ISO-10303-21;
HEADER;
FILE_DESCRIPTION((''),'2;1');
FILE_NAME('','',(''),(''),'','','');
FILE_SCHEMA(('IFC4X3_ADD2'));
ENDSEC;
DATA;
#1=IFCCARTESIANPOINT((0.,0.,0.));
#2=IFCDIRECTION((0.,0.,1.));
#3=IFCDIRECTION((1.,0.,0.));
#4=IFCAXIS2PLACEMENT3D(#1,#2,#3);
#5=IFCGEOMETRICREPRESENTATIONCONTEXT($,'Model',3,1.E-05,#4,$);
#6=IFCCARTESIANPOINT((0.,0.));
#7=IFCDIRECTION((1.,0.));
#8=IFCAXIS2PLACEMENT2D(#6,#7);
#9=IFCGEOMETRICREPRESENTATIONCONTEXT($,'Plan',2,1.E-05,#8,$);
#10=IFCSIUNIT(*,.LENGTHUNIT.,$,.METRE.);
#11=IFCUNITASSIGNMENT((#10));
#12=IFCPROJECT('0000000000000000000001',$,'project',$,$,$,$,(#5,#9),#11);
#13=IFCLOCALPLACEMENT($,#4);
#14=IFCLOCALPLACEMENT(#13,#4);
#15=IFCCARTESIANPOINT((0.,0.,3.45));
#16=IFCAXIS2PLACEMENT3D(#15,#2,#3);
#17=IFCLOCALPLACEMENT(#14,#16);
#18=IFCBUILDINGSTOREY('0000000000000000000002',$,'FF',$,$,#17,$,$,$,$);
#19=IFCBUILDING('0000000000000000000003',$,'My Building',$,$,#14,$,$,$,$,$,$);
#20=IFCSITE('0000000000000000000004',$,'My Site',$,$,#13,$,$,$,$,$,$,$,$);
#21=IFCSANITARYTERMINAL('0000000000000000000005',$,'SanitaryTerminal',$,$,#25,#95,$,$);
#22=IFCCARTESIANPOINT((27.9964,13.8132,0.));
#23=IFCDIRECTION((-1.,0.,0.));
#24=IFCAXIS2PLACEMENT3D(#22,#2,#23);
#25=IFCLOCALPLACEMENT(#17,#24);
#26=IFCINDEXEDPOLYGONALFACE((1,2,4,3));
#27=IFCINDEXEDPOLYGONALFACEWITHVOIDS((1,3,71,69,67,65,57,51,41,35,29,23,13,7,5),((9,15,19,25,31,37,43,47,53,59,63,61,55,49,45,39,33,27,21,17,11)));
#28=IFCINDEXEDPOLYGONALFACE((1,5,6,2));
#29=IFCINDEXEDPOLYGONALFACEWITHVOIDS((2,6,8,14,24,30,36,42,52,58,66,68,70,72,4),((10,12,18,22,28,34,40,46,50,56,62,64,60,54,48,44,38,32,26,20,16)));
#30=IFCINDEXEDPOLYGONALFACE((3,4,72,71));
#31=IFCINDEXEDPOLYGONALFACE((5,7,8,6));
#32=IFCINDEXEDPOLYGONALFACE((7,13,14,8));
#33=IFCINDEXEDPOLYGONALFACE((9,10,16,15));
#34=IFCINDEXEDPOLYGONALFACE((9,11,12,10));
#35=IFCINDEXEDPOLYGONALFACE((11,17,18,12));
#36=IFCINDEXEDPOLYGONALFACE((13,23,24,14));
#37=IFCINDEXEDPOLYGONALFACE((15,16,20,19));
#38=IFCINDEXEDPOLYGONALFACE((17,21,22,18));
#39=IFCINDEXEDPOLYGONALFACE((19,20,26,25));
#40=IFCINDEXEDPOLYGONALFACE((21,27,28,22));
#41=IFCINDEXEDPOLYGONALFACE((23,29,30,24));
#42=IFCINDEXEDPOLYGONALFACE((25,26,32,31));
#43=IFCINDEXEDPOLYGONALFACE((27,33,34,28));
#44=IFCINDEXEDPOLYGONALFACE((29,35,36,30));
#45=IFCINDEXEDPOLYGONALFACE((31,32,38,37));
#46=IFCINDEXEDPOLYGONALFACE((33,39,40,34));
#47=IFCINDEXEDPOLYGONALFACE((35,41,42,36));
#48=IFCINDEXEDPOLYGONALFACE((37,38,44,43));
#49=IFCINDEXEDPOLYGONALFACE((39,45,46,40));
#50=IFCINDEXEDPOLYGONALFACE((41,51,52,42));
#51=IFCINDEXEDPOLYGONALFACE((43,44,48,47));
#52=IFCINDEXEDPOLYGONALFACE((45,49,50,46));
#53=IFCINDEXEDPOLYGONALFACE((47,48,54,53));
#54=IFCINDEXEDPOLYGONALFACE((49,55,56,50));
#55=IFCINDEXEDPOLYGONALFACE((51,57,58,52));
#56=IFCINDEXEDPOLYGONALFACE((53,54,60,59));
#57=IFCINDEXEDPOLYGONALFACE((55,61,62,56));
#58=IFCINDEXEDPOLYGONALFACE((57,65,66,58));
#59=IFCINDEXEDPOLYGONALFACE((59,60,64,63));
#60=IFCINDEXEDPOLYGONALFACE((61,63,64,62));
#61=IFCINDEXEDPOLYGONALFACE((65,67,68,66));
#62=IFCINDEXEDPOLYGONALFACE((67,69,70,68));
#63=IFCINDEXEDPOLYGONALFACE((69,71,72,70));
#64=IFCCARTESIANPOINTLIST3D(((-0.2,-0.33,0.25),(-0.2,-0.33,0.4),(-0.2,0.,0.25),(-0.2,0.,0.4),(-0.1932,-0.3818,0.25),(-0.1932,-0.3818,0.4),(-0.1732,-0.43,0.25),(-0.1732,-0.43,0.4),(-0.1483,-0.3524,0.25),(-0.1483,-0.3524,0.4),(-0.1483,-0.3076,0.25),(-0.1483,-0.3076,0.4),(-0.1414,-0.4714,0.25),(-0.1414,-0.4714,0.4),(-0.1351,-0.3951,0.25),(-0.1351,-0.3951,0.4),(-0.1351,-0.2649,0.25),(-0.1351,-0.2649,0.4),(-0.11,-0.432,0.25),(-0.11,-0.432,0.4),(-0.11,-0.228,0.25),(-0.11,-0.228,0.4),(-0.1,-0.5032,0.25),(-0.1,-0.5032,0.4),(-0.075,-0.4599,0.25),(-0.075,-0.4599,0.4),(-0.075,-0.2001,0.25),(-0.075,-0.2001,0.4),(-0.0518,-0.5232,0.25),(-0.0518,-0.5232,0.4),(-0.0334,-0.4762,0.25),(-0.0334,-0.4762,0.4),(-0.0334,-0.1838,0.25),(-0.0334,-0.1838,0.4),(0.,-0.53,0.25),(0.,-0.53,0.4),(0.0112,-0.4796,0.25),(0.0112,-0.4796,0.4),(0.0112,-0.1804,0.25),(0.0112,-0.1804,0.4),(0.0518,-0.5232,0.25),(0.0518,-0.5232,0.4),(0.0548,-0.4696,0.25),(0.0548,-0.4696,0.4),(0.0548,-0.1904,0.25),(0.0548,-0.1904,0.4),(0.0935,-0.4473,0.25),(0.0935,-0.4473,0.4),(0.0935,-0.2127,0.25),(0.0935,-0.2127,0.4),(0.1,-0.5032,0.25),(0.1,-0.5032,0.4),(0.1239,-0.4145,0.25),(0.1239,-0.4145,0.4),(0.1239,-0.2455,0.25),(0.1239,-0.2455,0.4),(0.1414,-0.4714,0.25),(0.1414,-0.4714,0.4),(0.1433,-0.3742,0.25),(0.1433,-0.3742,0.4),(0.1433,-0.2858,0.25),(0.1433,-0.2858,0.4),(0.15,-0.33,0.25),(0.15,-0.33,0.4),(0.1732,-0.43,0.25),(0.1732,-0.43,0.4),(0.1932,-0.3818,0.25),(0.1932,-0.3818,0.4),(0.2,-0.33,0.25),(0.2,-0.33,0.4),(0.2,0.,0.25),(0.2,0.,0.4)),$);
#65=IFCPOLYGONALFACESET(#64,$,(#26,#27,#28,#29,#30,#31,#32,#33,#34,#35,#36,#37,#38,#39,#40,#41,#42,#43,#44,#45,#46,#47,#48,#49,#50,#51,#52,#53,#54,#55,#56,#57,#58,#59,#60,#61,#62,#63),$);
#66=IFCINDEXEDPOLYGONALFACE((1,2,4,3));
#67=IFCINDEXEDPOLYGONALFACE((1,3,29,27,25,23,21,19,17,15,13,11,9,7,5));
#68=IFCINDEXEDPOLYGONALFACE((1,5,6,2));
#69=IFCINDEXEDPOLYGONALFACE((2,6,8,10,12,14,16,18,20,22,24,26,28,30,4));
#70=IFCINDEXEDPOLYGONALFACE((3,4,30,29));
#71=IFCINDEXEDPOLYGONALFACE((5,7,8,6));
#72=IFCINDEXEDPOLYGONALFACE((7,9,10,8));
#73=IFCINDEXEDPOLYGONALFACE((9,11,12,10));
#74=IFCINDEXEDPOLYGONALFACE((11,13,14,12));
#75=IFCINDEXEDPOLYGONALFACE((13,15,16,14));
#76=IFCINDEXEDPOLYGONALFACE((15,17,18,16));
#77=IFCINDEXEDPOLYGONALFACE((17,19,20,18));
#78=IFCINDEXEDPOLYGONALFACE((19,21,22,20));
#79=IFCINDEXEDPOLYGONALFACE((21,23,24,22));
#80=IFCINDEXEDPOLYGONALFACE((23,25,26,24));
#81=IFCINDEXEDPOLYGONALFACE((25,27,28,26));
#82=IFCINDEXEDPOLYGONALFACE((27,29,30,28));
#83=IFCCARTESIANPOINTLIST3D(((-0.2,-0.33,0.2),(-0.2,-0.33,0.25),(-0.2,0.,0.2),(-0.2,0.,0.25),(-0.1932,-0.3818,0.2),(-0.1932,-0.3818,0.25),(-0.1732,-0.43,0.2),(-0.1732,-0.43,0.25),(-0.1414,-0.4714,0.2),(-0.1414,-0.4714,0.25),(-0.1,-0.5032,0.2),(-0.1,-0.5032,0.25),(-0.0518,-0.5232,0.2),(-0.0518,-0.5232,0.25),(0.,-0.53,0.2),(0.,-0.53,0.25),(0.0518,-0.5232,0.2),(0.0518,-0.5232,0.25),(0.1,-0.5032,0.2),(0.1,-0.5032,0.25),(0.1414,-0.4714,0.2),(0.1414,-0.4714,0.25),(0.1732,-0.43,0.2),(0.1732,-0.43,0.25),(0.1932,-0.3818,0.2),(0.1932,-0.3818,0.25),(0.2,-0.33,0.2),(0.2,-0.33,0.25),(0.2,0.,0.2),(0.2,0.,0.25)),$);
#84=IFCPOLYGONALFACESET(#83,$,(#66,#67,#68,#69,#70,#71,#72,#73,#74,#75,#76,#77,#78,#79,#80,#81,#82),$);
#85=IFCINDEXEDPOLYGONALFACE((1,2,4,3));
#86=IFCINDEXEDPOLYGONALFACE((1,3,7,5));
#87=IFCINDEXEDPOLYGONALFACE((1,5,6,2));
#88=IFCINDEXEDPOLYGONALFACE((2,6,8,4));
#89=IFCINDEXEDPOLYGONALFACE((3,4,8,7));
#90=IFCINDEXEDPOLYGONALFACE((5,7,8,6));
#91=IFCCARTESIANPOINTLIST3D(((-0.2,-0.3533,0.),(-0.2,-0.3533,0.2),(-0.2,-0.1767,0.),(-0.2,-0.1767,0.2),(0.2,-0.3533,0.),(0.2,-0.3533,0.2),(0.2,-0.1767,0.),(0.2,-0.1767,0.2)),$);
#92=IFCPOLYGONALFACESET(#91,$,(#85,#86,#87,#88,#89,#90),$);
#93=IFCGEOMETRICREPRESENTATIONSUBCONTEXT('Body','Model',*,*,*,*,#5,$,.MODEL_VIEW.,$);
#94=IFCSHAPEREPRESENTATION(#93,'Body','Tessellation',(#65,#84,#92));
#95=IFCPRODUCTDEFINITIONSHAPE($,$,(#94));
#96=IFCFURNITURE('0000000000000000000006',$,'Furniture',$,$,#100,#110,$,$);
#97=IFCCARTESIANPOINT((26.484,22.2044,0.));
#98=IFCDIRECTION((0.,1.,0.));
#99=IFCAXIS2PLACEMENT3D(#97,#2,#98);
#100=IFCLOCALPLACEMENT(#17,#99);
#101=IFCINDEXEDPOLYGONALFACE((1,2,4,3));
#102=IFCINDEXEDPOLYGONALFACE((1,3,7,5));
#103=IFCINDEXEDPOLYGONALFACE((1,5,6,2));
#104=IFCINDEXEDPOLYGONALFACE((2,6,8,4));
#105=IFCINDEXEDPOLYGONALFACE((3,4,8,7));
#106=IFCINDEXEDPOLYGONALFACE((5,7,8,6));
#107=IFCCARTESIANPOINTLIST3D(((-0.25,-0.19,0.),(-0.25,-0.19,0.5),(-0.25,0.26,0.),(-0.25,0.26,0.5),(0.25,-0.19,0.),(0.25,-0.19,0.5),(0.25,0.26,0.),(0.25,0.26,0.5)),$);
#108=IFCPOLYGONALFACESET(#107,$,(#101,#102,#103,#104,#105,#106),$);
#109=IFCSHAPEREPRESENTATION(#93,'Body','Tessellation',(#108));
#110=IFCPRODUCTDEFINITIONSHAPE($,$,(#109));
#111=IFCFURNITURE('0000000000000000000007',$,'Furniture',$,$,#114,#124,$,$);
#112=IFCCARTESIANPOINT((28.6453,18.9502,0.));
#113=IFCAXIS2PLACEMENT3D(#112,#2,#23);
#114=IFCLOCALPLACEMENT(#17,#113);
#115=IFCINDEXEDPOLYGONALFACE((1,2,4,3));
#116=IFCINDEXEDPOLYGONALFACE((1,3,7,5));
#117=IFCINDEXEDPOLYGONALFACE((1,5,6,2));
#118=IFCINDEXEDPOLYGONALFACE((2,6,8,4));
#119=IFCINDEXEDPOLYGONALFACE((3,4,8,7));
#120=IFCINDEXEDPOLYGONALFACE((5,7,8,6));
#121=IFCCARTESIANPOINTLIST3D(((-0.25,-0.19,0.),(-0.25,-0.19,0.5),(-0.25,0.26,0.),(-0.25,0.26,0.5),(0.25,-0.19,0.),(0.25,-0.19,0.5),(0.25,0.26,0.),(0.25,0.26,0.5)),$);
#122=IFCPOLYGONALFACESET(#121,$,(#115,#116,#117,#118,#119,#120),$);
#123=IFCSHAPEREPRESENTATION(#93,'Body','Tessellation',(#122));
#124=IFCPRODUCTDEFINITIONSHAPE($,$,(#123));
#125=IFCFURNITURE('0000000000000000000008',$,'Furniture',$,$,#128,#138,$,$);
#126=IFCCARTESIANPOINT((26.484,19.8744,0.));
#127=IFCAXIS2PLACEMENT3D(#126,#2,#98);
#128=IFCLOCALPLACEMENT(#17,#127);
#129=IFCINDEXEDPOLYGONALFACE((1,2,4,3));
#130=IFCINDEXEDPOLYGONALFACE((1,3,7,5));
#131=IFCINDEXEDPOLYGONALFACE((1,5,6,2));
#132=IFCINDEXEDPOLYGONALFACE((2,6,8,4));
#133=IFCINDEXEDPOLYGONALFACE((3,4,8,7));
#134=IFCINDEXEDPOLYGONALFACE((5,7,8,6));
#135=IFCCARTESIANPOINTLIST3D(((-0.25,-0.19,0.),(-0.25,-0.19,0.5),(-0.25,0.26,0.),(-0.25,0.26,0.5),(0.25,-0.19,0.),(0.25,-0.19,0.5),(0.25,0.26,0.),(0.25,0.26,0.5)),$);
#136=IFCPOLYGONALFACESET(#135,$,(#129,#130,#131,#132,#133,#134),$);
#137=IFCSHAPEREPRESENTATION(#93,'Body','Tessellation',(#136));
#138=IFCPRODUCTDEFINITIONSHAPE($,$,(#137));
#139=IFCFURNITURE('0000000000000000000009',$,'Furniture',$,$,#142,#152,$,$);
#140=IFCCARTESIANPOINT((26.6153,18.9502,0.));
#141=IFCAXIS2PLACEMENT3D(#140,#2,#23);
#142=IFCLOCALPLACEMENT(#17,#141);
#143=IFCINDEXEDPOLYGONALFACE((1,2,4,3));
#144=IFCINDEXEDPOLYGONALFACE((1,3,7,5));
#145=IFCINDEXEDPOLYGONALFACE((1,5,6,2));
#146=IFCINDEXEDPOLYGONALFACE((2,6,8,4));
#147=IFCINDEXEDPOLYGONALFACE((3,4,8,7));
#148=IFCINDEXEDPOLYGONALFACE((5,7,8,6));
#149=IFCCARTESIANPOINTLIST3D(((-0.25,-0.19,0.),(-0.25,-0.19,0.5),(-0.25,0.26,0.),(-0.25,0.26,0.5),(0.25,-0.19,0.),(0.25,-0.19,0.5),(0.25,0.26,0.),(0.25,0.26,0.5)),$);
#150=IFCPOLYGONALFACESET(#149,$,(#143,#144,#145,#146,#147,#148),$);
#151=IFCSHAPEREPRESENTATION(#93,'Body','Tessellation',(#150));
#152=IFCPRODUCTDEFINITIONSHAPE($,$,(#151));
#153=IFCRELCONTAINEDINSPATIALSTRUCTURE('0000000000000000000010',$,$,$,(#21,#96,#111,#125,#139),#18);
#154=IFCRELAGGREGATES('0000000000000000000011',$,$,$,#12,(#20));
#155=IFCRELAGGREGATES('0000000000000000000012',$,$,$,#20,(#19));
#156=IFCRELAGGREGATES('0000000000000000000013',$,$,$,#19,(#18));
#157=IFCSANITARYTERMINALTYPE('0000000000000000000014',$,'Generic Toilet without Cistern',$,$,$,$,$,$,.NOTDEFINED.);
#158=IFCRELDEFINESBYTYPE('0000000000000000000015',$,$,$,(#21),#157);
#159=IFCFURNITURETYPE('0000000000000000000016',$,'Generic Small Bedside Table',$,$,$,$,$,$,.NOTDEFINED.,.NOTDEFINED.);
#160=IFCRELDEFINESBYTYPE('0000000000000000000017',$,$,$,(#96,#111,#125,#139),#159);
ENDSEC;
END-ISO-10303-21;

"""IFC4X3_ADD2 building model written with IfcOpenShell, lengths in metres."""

from ifc_helpers import new_model, entity, si_unit, frame, frame_2d, origin_with_axes, origin_2d_with_axis, place, context, subcontext, project, spatial, line, arc, indexed_curve, circle_curve, outline, extrude, shape, source, transform, mapped, type_object, type_shapes, element, save


model = new_model("IFC4X3_ADD2")

# Units and contexts
model_context = context("Model", 3, precision=1e-05, world=origin_with_axes())
plan_context = context("Plan", 2, precision=1e-05, world=origin_2d_with_axis())
body_context_1 = subcontext(model_context, "Body", "Model", "MODEL_VIEW")
body_context_2 = subcontext(plan_context, "Body", "Plan", "PLAN_VIEW")
ifc_project = project(units=[si_unit("LENGTHUNIT", "METRE")], contexts=[model_context, plan_context])

# Site, building, storey
site_placement = place(None, origin_with_axes())
site = spatial("IfcSite", under=ifc_project, at=site_placement, Name="My Site")
building_placement = place(site_placement, origin_with_axes())
building = spatial("IfcBuilding", under=site, at=building_placement, Name="My Building")
storey_placement = place(building_placement, frame((0.0, 0.0, 3.45), z_axis=(0.0, 0.0, 1.0), x_axis=(1.0, 0.0, 0.0)))
storey = spatial("IfcBuildingStorey", under=building, at=storey_placement, Name="FF")

# Sanitary terminal
sanitary_terminal_type_1 = type_object("IfcSanitaryTerminalType", Name="Generic Toilet without Cistern", PredefinedType="NOTDEFINED")
shared_shape_1 = source(origin_with_axes(), body_context_1, "Body", "SweptSolid", [
    extrude(outline(indexed_curve([(-0.2, 0.0), (0.2, 0.0), (0.2, -0.33), (0.1414, -0.4714), (0.0, -0.53), (-0.1414, -0.4714), (-0.2, -0.33)], segments=[line(1, 2), line(2, 3), arc(3, 4, 5), arc(5, 6, 7), line(7, 1)]), holes=[circle_curve(frame_2d((0.0, -0.33)), 0.15)]), frame((0.0, 0.0, 0.25), z_axis=(0.0, 0.0, 1.0), x_axis=(1.0, 0.0, 0.0)), (0.0, 0.0, 1.0), 0.15),
    extrude(outline(indexed_curve([(-0.2, 0.0), (0.2, 0.0), (0.2, -0.33), (0.1414, -0.4714), (0.0, -0.53), (-0.1414, -0.4714), (-0.2, -0.33)], segments=[line(1, 2), line(2, 3), arc(3, 4, 5), arc(5, 6, 7), line(7, 1)])), frame((0.0, 0.0, 0.2), z_axis=(0.0, 0.0, 1.0), x_axis=(1.0, 0.0, 0.0)), (0.0, 0.0, 1.0), 0.05),
    extrude(outline(indexed_curve([(-0.2, -0.1767), (0.2, -0.1767), (0.2, -0.3533), (-0.2, -0.3533)], segments=[line(1, 2, 3, 4, 1)])), origin_with_axes(), (0.0, 0.0, 1.0), 0.2),
])
shared_shape_2 = source(origin_with_axes(), body_context_2, "Body", "Annotation2D", [
    entity("IfcGeometricCurveSet", [entity("IfcIndexedPolyCurve", entity("IfcCartesianPointList2D", [[-0.1068, -0.124], [-0.0957, -0.1129], [-0.0804, -0.1088], [0.0804, -0.1088], [0.0957, -0.1129], [0.1068, -0.124], [0.1109, -0.1393], [0.1109, -0.3476], [0.1025, -0.3926], [0.0784, -0.4308], [0.0424, -0.4563], [0.0, -0.4652], [-0.0424, -0.4563], [-0.0784, -0.4308], [-0.1025, -0.3926], [-0.1109, -0.3476], [-0.1109, -0.1393]]), [entity("IfcLineIndex", [1, 2, 3, 4, 5, 6, 7, 8, 9, 10, 11, 12, 13, 14, 15, 16, 17, 1])]), entity("IfcIndexedPolyCurve", entity("IfcCartesianPointList2D", [[-0.1962, -0.2314], [-0.1848, -0.301], [-0.1764, -0.3339], [-0.1663, -0.3651], [-0.1546, -0.3944], [-0.1414, -0.4213], [-0.1269, -0.4458], [-0.1111, -0.4675], [-0.0943, -0.4862], [-0.0765, -0.5018], [-0.0581, -0.514], [-0.039, -0.5229], [-0.0196, -0.5282], [0.0, -0.53], [0.0196, -0.5282], [0.039, -0.5229], [0.0581, -0.514], [0.0765, -0.5018], [0.0943, -0.4862], [0.1111, -0.4675], [0.1269, -0.4458], [0.1414, -0.4213], [0.1546, -0.3944], [0.1663, -0.3651], [0.1764, -0.3339], [0.1848, -0.301], [0.1962, -0.2314], [0.2, -0.159], [0.1872, 0.0], [-0.1872, 0.0], [-0.2, -0.159]]), [entity("IfcLineIndex", [1, 2, 3, 4, 5, 6, 7, 8, 9, 10, 11, 12, 13, 14, 15, 16, 17, 18, 19, 20, 21, 22, 23, 24, 25, 26, 27, 28, 29, 30, 31, 1])])]),
])
type_shapes(sanitary_terminal_type_1, [shared_shape_1, shared_shape_2])
sanitary_terminal_1_placement = place(storey_placement, frame((27.9964, 13.8132, 0.0), z_axis=(0.0, 0.0, 1.0), x_axis=(-1.0, 0.0, 0.0)))
element("IfcSanitaryTerminal", 1, at=sanitary_terminal_1_placement, inside=storey, type_object=sanitary_terminal_type_1, Name="SanitaryTerminal", shapes=[
    shape(body_context_1, "Body", "MappedRepresentation", [mapped(shared_shape_1, transform((0.0, 0.0, 0.0), x_axis=(1.0, 0.0, 0.0), y_axis=(0.0, 1.0, 0.0), z_axis=(0.0, 0.0, 1.0), scale=1.0))]),
    shape(body_context_2, "Body", "MappedRepresentation", [mapped(shared_shape_2, transform((0.0, 0.0, 0.0), x_axis=(1.0, 0.0, 0.0), y_axis=(0.0, 1.0, 0.0), z_axis=(0.0, 0.0, 1.0), scale=1.0))]),
])

# Furniture
furniture_type_1 = type_object("IfcFurnitureType", Name="Generic Small Bedside Table", AssemblyPlace="NOTDEFINED", PredefinedType="NOTDEFINED")
shared_shape_3 = source(origin_with_axes(), body_context_1, "Body", "SweptSolid", [
    extrude(outline(indexed_curve([(0.5, 0.45), (0.5, 0.0), (0.0, 0.0), (0.0, 0.45)], segments=[line(4, 1), line(1, 2), line(2, 3), line(3, 4)], self_intersect=False)), frame((-0.25, -0.19, 0.0), z_axis=(0.0, 0.0, 1.0), x_axis=(1.0, 0.0, 0.0)), (0.0, 0.0, 1.0), 0.5),
])
shared_shape_4 = source(origin_with_axes(), body_context_2, "Body", "Annotation2D", [
    entity("IfcGeometricCurveSet", [entity("IfcIndexedPolyCurve", entity("IfcCartesianPointList2D", [[-0.25, -0.19], [0.25, -0.19], [0.25, 0.26], [-0.25, 0.26]]), [entity("IfcLineIndex", [1, 2]), entity("IfcLineIndex", [2, 3]), entity("IfcLineIndex", [3, 4]), entity("IfcLineIndex", [4, 1])])]),
])
type_shapes(furniture_type_1, [shared_shape_3, shared_shape_4])
for number, where, z_axis, x_axis, name in (
    (2, (26.484, 22.2044, 0.0), (0.0, 0.0, 1.0), (0.0, 1.0, 0.0), "Furniture"),
    (3, (28.6453, 18.9502, 0.0), (0.0, 0.0, 1.0), (-1.0, 0.0, 0.0), "Furniture"),
    (4, (26.484, 19.8744, 0.0), (0.0, 0.0, 1.0), (0.0, 1.0, 0.0), "Furniture"),
    (5, (26.6153, 18.9502, 0.0), (0.0, 0.0, 1.0), (-1.0, 0.0, 0.0), "Furniture"),
):
    element("IfcFurniture", number, at=place(storey_placement, frame(where, z_axis=z_axis, x_axis=x_axis)), inside=storey, type_object=furniture_type_1, Name=name, shapes=[
        shape(body_context_1, "Body", "MappedRepresentation", [mapped(shared_shape_3, transform((0.0, 0.0, 0.0), x_axis=(1.0, 0.0, 0.0), y_axis=(0.0, 1.0, 0.0), z_axis=(0.0, 0.0, 1.0), scale=1.0))]),
        shape(body_context_2, "Body", "MappedRepresentation", [mapped(shared_shape_4, transform((0.0, 0.0, 0.0), x_axis=(1.0, 0.0, 0.0), y_axis=(0.0, 1.0, 0.0), z_axis=(0.0, 0.0, 1.0), scale=1.0))]),
    ])

save(model, "model.ifc")
